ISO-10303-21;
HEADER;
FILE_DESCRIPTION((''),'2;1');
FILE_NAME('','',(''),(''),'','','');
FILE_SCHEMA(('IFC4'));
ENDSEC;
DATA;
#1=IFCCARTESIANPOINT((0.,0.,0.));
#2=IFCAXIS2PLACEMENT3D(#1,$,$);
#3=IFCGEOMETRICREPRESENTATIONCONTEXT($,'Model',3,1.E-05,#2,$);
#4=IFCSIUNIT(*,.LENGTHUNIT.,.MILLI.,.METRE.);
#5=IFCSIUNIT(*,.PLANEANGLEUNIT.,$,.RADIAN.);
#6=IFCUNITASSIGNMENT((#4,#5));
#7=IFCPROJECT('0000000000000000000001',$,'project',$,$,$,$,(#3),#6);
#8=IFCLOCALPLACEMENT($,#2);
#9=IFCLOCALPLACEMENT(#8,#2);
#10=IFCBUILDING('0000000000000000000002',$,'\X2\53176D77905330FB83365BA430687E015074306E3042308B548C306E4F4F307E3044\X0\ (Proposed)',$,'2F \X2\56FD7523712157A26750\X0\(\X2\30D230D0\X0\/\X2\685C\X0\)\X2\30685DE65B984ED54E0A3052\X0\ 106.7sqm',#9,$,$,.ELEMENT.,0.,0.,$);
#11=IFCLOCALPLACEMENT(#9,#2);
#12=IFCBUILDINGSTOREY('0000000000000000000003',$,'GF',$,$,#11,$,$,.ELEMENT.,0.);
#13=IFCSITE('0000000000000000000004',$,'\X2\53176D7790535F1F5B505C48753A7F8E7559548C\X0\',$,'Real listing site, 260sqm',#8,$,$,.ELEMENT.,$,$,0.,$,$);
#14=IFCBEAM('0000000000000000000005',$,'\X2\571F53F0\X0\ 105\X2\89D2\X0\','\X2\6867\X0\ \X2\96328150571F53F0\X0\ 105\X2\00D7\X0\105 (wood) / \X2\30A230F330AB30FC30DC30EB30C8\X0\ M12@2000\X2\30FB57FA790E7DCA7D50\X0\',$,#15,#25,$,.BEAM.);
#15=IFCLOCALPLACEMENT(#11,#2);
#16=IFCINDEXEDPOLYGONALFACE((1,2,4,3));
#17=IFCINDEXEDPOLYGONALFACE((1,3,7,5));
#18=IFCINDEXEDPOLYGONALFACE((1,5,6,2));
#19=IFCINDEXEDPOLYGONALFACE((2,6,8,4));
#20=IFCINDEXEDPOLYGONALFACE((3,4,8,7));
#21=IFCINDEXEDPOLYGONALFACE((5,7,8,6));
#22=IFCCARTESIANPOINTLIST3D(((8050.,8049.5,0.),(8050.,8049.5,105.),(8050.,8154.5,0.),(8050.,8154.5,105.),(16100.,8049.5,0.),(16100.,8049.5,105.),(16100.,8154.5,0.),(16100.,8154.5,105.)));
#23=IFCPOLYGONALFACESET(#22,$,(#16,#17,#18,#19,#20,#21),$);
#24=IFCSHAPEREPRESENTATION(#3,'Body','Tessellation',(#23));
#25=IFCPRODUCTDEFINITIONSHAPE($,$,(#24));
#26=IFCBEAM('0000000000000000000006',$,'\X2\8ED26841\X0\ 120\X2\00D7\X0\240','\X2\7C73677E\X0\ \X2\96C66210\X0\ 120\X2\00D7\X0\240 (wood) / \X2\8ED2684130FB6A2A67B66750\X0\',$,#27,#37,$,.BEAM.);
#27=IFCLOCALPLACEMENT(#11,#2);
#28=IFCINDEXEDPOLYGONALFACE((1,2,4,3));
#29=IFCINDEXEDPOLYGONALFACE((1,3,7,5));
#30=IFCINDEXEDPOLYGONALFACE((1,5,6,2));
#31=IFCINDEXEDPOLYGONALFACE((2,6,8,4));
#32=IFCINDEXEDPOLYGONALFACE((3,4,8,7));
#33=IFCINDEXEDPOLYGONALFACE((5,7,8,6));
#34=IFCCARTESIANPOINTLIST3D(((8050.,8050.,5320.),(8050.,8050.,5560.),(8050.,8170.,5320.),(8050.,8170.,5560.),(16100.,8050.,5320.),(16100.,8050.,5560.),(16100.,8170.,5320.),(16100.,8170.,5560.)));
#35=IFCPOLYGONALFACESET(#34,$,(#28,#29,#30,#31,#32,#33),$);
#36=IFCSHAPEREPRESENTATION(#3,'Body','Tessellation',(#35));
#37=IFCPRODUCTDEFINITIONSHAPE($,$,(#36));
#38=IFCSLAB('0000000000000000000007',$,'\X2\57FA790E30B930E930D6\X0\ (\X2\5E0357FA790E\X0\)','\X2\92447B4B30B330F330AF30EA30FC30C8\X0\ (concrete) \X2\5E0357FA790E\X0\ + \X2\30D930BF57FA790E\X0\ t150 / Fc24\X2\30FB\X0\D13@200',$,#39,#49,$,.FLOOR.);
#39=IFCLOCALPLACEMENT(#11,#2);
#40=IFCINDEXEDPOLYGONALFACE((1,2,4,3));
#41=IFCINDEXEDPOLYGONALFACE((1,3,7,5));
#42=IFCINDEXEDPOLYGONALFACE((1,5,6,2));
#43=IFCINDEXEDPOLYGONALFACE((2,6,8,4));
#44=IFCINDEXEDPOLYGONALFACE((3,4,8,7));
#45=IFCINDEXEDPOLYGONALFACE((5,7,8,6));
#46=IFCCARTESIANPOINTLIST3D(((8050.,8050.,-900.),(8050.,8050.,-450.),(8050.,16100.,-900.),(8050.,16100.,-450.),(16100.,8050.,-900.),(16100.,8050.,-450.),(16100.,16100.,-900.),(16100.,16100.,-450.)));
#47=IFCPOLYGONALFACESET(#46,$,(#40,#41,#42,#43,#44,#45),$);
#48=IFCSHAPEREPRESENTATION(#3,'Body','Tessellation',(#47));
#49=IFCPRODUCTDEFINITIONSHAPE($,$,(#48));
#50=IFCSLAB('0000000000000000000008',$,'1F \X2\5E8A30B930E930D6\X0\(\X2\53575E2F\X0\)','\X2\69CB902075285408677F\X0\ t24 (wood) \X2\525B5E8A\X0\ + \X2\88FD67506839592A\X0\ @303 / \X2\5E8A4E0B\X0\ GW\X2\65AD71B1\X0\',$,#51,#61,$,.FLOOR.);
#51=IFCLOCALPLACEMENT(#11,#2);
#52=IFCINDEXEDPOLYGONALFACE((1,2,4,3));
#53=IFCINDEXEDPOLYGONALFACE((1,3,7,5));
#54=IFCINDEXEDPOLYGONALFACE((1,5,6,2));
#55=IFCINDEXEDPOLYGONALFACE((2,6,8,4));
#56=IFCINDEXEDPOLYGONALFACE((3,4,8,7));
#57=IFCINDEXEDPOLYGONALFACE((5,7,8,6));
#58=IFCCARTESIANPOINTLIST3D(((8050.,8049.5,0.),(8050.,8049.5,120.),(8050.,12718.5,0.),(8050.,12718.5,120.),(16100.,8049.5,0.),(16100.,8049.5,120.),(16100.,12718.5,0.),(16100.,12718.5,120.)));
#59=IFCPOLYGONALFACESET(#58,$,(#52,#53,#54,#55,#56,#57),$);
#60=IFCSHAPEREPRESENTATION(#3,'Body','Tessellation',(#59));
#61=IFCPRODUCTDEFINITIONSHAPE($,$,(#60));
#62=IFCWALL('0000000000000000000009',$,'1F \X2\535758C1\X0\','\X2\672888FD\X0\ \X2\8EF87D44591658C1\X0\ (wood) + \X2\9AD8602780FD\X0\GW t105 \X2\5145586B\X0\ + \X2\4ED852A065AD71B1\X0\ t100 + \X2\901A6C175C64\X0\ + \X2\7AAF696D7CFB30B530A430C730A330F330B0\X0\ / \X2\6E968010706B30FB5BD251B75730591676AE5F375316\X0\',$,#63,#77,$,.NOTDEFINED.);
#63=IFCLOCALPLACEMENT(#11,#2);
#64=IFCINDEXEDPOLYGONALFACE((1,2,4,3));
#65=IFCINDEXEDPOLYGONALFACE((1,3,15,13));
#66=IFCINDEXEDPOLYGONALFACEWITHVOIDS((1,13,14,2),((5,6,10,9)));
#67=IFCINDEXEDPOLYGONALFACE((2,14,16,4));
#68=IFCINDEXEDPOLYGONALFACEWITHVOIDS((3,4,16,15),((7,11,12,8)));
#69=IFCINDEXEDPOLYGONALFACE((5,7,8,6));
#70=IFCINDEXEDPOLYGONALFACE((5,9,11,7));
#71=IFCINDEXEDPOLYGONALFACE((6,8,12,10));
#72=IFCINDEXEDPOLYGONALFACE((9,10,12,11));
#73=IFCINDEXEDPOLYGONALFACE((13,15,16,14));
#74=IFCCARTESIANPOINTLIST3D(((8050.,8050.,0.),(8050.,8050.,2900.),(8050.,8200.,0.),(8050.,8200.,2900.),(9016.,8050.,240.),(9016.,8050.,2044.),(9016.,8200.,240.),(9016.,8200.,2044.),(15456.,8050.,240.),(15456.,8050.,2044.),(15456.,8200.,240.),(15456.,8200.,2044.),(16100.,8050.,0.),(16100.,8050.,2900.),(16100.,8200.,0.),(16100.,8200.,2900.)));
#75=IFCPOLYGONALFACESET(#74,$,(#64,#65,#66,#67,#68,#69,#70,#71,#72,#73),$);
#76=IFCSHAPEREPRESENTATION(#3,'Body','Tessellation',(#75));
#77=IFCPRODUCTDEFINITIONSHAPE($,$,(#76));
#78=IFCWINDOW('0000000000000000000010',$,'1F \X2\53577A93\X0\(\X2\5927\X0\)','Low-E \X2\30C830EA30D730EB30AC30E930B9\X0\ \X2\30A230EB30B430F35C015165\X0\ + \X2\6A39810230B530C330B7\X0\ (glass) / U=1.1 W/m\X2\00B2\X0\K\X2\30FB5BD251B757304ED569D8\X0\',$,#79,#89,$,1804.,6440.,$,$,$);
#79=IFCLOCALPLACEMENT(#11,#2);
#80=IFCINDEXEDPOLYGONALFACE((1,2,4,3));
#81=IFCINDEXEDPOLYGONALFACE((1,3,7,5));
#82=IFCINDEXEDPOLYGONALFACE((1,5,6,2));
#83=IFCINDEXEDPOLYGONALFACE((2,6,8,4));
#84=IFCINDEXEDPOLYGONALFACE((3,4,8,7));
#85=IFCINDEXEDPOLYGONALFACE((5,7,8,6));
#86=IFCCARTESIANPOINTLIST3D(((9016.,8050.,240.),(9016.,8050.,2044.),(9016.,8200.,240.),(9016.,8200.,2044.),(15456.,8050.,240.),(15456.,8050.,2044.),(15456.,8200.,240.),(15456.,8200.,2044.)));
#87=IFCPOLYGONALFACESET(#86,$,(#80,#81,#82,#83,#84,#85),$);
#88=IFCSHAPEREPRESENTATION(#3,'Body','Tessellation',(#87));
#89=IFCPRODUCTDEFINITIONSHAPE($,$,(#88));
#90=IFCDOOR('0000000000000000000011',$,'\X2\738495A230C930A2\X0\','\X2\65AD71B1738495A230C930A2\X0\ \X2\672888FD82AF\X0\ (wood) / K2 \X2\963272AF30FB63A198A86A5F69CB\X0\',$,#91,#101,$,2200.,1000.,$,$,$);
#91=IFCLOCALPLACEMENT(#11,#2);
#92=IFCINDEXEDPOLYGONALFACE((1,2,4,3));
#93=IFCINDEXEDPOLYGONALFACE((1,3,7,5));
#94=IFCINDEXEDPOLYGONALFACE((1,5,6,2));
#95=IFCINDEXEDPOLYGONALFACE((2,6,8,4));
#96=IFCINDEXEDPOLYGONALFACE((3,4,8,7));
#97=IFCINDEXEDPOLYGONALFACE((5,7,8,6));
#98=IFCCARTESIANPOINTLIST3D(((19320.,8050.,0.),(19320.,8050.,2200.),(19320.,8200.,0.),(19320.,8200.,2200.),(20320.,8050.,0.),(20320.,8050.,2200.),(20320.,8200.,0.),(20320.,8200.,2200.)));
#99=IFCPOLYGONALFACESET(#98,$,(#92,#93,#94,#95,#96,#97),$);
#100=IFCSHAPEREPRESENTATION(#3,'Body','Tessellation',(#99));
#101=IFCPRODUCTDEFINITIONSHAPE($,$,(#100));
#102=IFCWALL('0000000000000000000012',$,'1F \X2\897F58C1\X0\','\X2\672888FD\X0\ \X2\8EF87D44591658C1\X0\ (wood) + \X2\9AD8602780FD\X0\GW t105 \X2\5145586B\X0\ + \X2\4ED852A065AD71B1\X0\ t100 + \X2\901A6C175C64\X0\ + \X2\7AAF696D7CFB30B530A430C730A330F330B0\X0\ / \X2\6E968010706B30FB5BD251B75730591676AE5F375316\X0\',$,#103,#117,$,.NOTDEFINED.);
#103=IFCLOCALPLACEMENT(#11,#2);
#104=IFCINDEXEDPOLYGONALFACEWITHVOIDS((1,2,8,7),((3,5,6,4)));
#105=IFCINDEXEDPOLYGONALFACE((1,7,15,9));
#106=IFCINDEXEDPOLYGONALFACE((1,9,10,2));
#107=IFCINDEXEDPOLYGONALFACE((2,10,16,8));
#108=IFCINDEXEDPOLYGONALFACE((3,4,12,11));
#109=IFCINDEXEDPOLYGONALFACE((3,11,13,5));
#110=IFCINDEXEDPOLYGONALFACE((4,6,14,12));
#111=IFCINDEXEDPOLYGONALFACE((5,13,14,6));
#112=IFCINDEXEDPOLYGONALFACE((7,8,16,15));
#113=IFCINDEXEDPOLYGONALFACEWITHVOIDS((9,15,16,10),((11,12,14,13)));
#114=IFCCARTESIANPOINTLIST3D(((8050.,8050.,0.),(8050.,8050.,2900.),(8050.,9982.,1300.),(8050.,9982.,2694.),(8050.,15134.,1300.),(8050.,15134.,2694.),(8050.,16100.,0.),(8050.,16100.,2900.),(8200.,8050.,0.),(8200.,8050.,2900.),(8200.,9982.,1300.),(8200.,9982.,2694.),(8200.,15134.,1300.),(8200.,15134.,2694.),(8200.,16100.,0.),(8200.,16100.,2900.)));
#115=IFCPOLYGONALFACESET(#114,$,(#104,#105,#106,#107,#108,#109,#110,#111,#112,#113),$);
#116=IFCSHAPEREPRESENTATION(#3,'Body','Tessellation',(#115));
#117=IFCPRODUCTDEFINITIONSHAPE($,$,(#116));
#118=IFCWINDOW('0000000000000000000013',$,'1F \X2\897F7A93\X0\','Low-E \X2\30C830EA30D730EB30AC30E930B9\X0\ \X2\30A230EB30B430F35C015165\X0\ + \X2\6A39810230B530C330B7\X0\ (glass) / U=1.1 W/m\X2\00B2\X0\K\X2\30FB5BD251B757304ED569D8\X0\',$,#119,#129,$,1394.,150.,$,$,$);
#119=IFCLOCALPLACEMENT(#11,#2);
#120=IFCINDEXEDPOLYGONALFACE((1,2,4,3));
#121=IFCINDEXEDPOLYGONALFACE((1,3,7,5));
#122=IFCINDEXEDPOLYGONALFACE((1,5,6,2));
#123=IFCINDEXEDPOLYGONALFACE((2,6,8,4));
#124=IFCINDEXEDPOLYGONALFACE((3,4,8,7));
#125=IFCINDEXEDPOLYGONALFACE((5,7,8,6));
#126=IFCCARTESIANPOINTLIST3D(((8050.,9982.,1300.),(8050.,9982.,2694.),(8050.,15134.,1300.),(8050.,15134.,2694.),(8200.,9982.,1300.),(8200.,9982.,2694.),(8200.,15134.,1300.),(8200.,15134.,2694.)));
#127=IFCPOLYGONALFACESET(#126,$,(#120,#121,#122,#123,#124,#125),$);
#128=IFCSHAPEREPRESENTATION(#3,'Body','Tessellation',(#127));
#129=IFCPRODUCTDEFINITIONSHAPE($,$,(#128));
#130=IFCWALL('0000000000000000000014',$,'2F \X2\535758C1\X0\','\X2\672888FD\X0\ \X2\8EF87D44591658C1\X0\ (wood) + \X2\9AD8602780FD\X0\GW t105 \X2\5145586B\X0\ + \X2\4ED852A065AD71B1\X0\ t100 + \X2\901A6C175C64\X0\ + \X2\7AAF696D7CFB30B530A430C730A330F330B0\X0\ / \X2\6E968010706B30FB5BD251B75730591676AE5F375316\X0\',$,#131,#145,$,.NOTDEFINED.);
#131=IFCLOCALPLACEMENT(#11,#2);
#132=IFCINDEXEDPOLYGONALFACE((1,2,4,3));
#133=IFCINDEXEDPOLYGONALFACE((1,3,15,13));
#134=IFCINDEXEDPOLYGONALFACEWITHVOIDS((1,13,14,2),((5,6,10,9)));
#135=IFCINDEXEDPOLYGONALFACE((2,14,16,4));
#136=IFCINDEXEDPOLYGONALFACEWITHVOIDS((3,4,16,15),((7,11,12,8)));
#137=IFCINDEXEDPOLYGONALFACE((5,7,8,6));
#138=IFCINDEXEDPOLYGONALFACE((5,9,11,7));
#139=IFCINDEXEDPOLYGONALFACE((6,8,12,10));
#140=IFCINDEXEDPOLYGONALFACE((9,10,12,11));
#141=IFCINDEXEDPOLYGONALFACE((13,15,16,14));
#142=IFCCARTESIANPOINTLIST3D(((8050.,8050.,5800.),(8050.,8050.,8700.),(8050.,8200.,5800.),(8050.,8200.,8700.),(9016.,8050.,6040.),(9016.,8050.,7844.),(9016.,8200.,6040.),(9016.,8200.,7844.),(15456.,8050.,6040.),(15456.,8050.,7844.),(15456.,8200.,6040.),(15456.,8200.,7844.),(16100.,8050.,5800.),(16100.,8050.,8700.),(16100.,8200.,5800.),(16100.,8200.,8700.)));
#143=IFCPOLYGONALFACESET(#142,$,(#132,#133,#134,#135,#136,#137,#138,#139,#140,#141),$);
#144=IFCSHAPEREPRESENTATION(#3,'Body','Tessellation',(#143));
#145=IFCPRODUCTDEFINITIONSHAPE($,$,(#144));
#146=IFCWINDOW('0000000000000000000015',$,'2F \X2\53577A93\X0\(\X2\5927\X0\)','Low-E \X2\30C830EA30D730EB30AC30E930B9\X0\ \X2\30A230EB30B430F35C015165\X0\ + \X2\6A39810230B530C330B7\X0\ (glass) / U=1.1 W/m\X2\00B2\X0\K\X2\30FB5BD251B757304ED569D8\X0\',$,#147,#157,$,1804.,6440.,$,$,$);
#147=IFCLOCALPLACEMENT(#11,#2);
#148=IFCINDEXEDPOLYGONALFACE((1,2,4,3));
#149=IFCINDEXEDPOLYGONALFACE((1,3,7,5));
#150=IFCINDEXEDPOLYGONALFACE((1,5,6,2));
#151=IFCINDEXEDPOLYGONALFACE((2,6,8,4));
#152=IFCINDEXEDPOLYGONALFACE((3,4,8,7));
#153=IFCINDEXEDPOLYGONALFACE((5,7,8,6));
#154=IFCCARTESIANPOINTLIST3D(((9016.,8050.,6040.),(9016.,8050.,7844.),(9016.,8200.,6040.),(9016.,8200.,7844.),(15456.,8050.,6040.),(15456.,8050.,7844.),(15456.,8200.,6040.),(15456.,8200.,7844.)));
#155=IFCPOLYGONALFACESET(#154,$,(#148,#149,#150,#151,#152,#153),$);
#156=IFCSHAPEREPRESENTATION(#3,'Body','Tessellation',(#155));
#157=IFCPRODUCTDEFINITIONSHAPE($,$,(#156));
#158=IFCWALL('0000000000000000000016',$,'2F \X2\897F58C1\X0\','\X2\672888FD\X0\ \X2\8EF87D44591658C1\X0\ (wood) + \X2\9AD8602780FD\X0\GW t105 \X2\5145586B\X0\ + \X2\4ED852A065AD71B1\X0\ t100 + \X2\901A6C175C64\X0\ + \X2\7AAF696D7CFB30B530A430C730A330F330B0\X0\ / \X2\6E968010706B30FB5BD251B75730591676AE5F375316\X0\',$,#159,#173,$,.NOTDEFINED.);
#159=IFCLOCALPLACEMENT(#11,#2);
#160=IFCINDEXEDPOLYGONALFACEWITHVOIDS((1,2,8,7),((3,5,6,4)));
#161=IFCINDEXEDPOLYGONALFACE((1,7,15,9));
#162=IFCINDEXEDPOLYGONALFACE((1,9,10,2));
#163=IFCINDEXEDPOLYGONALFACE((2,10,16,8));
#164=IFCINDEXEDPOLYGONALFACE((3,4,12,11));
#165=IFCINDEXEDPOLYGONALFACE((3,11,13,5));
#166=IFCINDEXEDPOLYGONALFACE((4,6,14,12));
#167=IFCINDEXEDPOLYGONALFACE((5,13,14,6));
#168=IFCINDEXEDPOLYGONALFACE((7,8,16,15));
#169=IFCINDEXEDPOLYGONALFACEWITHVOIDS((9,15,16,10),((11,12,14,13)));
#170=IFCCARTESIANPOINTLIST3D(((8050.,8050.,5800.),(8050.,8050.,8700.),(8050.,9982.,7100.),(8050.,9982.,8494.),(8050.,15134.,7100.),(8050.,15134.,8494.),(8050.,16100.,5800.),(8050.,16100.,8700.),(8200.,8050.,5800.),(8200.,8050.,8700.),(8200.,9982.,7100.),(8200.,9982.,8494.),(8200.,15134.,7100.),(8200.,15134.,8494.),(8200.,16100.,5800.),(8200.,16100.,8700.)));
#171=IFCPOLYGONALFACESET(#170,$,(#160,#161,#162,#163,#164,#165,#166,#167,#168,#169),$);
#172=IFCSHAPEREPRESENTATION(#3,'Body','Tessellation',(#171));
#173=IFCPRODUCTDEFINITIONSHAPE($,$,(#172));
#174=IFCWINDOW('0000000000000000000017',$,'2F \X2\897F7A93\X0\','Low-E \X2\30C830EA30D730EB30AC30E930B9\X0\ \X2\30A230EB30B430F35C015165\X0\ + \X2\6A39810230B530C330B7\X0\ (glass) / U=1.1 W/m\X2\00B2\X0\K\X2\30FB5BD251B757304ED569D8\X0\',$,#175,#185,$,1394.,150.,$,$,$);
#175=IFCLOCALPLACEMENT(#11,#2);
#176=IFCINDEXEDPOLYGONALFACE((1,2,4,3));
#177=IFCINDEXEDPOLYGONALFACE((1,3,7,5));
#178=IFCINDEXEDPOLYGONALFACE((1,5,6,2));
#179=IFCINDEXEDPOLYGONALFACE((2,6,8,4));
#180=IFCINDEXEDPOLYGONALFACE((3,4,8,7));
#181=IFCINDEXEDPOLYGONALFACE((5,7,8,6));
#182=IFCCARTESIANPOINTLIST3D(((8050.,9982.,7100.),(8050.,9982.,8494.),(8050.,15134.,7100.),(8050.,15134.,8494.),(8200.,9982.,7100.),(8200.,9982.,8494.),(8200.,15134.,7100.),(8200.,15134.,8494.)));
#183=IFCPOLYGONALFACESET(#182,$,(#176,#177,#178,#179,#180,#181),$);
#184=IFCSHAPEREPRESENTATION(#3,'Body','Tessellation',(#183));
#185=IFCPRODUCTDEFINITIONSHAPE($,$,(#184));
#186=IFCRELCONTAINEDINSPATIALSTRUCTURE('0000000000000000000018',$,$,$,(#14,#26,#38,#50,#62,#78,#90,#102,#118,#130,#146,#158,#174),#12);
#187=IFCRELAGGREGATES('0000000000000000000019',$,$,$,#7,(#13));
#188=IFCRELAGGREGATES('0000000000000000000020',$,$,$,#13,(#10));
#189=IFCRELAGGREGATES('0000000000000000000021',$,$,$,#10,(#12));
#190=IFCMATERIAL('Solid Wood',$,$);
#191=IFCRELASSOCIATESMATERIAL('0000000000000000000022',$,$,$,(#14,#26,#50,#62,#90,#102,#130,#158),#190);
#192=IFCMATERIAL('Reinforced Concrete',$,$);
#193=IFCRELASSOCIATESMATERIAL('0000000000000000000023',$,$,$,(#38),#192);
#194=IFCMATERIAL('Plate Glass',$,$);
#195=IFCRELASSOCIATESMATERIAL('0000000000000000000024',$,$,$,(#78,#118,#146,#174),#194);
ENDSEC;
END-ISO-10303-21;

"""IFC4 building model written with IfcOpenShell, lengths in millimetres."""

from ifc_helpers import new_model, si_unit, frame, frame_2d, origin, place, context, project, spatial, rectangle, extrude, material, element, fill, save


model = new_model("IFC4")

# Units and contexts
model_context = context("Model", 3, precision=1e-05, world=origin())
ifc_project = project(units=[si_unit("LENGTHUNIT", "METRE", prefix="MILLI"), si_unit("PLANEANGLEUNIT", "RADIAN")], contexts=[model_context])

# Site, building, storey
site_placement = place(None, origin())
site = spatial("IfcSite", under=ifc_project, at=site_placement, Name="北海道弟子屈町美留和", ObjectType="Real listing site, 260sqm", CompositionType="ELEMENT", RefElevation=0.0)
building_placement = place(site_placement, origin())
building = spatial("IfcBuilding", under=site, at=building_placement, Name="北海道・茶室と縁側のある和の住まい (Proposed)", ObjectType="2F 国産無垢材(ヒバ/桜)と左官仕上げ 106.7sqm", CompositionType="ELEMENT", ElevationOfRefHeight=0.0, ElevationOfTerrain=0.0)
storey_placement = place(building_placement, origin())
storey = spatial("IfcBuildingStorey", under=building, at=storey_placement, Name="GF", CompositionType="ELEMENT", Elevation=0.0)

# Shared definitions
ifc_material_1 = material(Name="Solid Wood")

# Beams
beam_1_placement = place(storey_placement, frame((4025.0, 4025.0, 0.0)))
element("IfcBeam", 1, at=beam_1_placement, inside=storey, material=ifc_material_1, Name="土台 105角", Description="桧 防腐土台 105×105 (wood) / アンカーボルト M12@2000・基礎緊結", PredefinedType="BEAM", context=model_context, shape_type="SweptSolid", body=[
    extrude(rectangle(XDim=8050.0, YDim=105.0, at=frame_2d((4025.0, 52.0))), frame((4025.0, 4025.0, 0.0)), (0.0, 0.0, 1.0), 105.0),
])
beam_2_placement = place(storey_placement, frame((4025.0, 4025.0, 2660.0)))
element("IfcBeam", 2, at=beam_2_placement, inside=storey, material=ifc_material_1, Name="軒桁 120×240", Description="米松 集成 120×240 (wood) / 軒桁・横架材", PredefinedType="BEAM", context=model_context, shape_type="SweptSolid", body=[
    extrude(rectangle(XDim=8050.0, YDim=120.0, at=frame_2d((4025.0, 60.0))), frame((4025.0, 4025.0, 2660.0)), (0.0, 0.0, 1.0), 240.0),
])

# Slabs
ifc_material_2 = material(Name="Reinforced Concrete")
slab_1_placement = place(storey_placement, frame((4025.0, 4025.0, -450.0)))
element("IfcSlab", 3, at=slab_1_placement, inside=storey, material=ifc_material_2, Name="基礎スラブ (布基礎)", Description="鉄筋コンクリート (concrete) 布基礎 + ベタ基礎 t150 / Fc24・D13@200", PredefinedType="FLOOR", context=model_context, shape_type="SweptSolid", body=[
    extrude(rectangle(XDim=8050.0, YDim=8050.0, at=frame_2d((4025.0, 4025.0))), frame((4025.0, 4025.0, -450.0)), (0.0, 0.0, 1.0), 450.0),
])
slab_2_placement = place(storey_placement, frame((4025.0, 4025.0, 0.0)))
element("IfcSlab", 4, at=slab_2_placement, inside=storey, material=ifc_material_1, Name="1F 床スラブ(南帯)", Description="構造用合板 t24 (wood) 剛床 + 製材根太 @303 / 床下 GW断熱", PredefinedType="FLOOR", context=model_context, shape_type="SweptSolid", body=[
    extrude(rectangle(XDim=8050.0, YDim=4669.0, at=frame_2d((4025.0, 2334.0))), frame((4025.0, 4025.0, 0.0)), (0.0, 0.0, 1.0), 120.0),
])

# Wall, openings, window, door
wall_1_placement = place(storey_placement, frame((4025.0, 4025.0, 0.0)))
wall_1 = element("IfcWall", 5, at=wall_1_placement, inside=storey, material=ifc_material_1, Name="1F 南壁", Description="木製 軸組外壁 (wood) + 高性能GW t105 充填 + 付加断熱 t100 + 通気層 + 窯業系サイディング / 準耐火・寒冷地外皮強化", PredefinedType="NOTDEFINED", context=model_context, shape_type="SweptSolid", body=[
    extrude(rectangle(XDim=8050.0, YDim=150.0, at=frame_2d((4025.0, 75.0))), frame((4025.0, 4025.0, 0.0)), (0.0, 0.0, 1.0), 2900.0),
])
opening_1_placement = place(storey_placement, frame((4508.0, 4025.0, 120.0)))
opening_1 = element("IfcOpeningElement", 6, at=opening_1_placement, cuts=wall_1, PredefinedType="NOTDEFINED", context=model_context, shape_type="SweptSolid", body=[
    extrude(rectangle(XDim=6440.0, YDim=150.0, at=frame_2d((3220.0, 75.0))), frame((4508.0, 4025.0, 120.0)), (0.0, 0.0, 1.0), 1804.0),
])
opening_2_placement = place(storey_placement, frame((9660.0, 4025.0, 0.0)))
opening_2 = element("IfcOpeningElement", 7, at=opening_2_placement, cuts=wall_1, PredefinedType="NOTDEFINED", context=model_context, shape_type="SweptSolid", body=[
    extrude(rectangle(XDim=1000.0, YDim=150.0, at=frame_2d((500.0, 75.0))), frame((9660.0, 4025.0, 0.0)), (0.0, 0.0, 1.0), 2200.0),
])
ifc_material_3 = material(Name="Plate Glass")
window_1_placement = place(storey_placement, frame((4508.0, 4025.0, 120.0)))
window_1 = element("IfcWindow", 8, at=window_1_placement, inside=storey, material=ifc_material_3, Name="1F 南窓(大)", Description="Low-E トリプルガラス アルゴン封入 + 樹脂サッシ (glass) / U=1.1 W/m²K・寒冷地仕様", OverallHeight=1804.0, OverallWidth=6440.0, context=model_context, shape_type="SweptSolid", body=[
    extrude(rectangle(XDim=6440.0, YDim=150.0, at=frame_2d((3220.0, 75.0))), frame((4508.0, 4025.0, 120.0)), (0.0, 0.0, 1.0), 1804.0),
])
fill(opening_1, window_1)
door_placement = place(storey_placement, frame((9660.0, 4025.0, 0.0)))
door = element("IfcDoor", 9, at=door_placement, inside=storey, material=ifc_material_1, Name="玄関ドア", Description="断熱玄関ドア 木製芯 (wood) / K2 防犯・採風機構", OverallHeight=2200.0, OverallWidth=1000.0, context=model_context, shape_type="SweptSolid", body=[
    extrude(rectangle(XDim=1000.0, YDim=150.0, at=frame_2d((500.0, 75.0))), frame((9660.0, 4025.0, 0.0)), (0.0, 0.0, 1.0), 2200.0),
])
fill(opening_2, door)

# Walls, openings, windows
wall_2_placement = place(storey_placement, frame((4025.0, 4025.0, 0.0)))
wall_2 = element("IfcWall", 10, at=wall_2_placement, inside=storey, material=ifc_material_1, Name="1F 西壁", Description="木製 軸組外壁 (wood) + 高性能GW t105 充填 + 付加断熱 t100 + 通気層 + 窯業系サイディング / 準耐火・寒冷地外皮強化", PredefinedType="NOTDEFINED", context=model_context, shape_type="SweptSolid", body=[
    extrude(rectangle(XDim=150.0, YDim=8050.0, at=frame_2d((75.0, 4025.0))), frame((4025.0, 4025.0, 0.0)), (0.0, 0.0, 1.0), 2900.0),
])
opening_3_placement = place(storey_placement, frame((4025.0, 4991.0, 650.0)))
opening_3 = element("IfcOpeningElement", 11, at=opening_3_placement, cuts=wall_2, PredefinedType="NOTDEFINED", context=model_context, shape_type="SweptSolid", body=[
    extrude(rectangle(XDim=150.0, YDim=5152.0, at=frame_2d((75.0, 2576.0))), frame((4025.0, 4991.0, 650.0)), (0.0, 0.0, 1.0), 1394.0),
])
window_2_placement = place(storey_placement, frame((4025.0, 4991.0, 650.0)))
window_2 = element("IfcWindow", 12, at=window_2_placement, inside=storey, material=ifc_material_3, Name="1F 西窓", Description="Low-E トリプルガラス アルゴン封入 + 樹脂サッシ (glass) / U=1.1 W/m²K・寒冷地仕様", OverallHeight=1394.0, OverallWidth=150.0, context=model_context, shape_type="SweptSolid", body=[
    extrude(rectangle(XDim=150.0, YDim=5152.0, at=frame_2d((75.0, 2576.0))), frame((4025.0, 4991.0, 650.0)), (0.0, 0.0, 1.0), 1394.0),
])
fill(opening_3, window_2)
wall_3_placement = place(storey_placement, frame((4025.0, 4025.0, 2900.0)))
wall_3 = element("IfcWall", 13, at=wall_3_placement, inside=storey, material=ifc_material_1, Name="2F 南壁", Description="木製 軸組外壁 (wood) + 高性能GW t105 充填 + 付加断熱 t100 + 通気層 + 窯業系サイディング / 準耐火・寒冷地外皮強化", PredefinedType="NOTDEFINED", context=model_context, shape_type="SweptSolid", body=[
    extrude(rectangle(XDim=8050.0, YDim=150.0, at=frame_2d((4025.0, 75.0))), frame((4025.0, 4025.0, 2900.0)), (0.0, 0.0, 1.0), 2900.0),
])
opening_4_placement = place(storey_placement, frame((4508.0, 4025.0, 3020.0)))
opening_4 = element("IfcOpeningElement", 14, at=opening_4_placement, cuts=wall_3, PredefinedType="NOTDEFINED", context=model_context, shape_type="SweptSolid", body=[
    extrude(rectangle(XDim=6440.0, YDim=150.0, at=frame_2d((3220.0, 75.0))), frame((4508.0, 4025.0, 3020.0)), (0.0, 0.0, 1.0), 1804.0),
])
window_3_placement = place(storey_placement, frame((4508.0, 4025.0, 3020.0)))
window_3 = element("IfcWindow", 15, at=window_3_placement, inside=storey, material=ifc_material_3, Name="2F 南窓(大)", Description="Low-E トリプルガラス アルゴン封入 + 樹脂サッシ (glass) / U=1.1 W/m²K・寒冷地仕様", OverallHeight=1804.0, OverallWidth=6440.0, context=model_context, shape_type="SweptSolid", body=[
    extrude(rectangle(XDim=6440.0, YDim=150.0, at=frame_2d((3220.0, 75.0))), frame((4508.0, 4025.0, 3020.0)), (0.0, 0.0, 1.0), 1804.0),
])
fill(opening_4, window_3)
wall_4_placement = place(storey_placement, frame((4025.0, 4025.0, 2900.0)))
wall_4 = element("IfcWall", 16, at=wall_4_placement, inside=storey, material=ifc_material_1, Name="2F 西壁", Description="木製 軸組外壁 (wood) + 高性能GW t105 充填 + 付加断熱 t100 + 通気層 + 窯業系サイディング / 準耐火・寒冷地外皮強化", PredefinedType="NOTDEFINED", context=model_context, shape_type="SweptSolid", body=[
    extrude(rectangle(XDim=150.0, YDim=8050.0, at=frame_2d((75.0, 4025.0))), frame((4025.0, 4025.0, 2900.0)), (0.0, 0.0, 1.0), 2900.0),
])
opening_5_placement = place(storey_placement, frame((4025.0, 4991.0, 3550.0)))
opening_5 = element("IfcOpeningElement", 17, at=opening_5_placement, cuts=wall_4, PredefinedType="NOTDEFINED", context=model_context, shape_type="SweptSolid", body=[
    extrude(rectangle(XDim=150.0, YDim=5152.0, at=frame_2d((75.0, 2576.0))), frame((4025.0, 4991.0, 3550.0)), (0.0, 0.0, 1.0), 1394.0),
])
window_4_placement = place(storey_placement, frame((4025.0, 4991.0, 3550.0)))
window_4 = element("IfcWindow", 18, at=window_4_placement, inside=storey, material=ifc_material_3, Name="2F 西窓", Description="Low-E トリプルガラス アルゴン封入 + 樹脂サッシ (glass) / U=1.1 W/m²K・寒冷地仕様", OverallHeight=1394.0, OverallWidth=150.0, context=model_context, shape_type="SweptSolid", body=[
    extrude(rectangle(XDim=150.0, YDim=5152.0, at=frame_2d((75.0, 2576.0))), frame((4025.0, 4991.0, 3550.0)), (0.0, 0.0, 1.0), 1394.0),
])
fill(opening_5, window_4)

save(model, "model.ifc")
